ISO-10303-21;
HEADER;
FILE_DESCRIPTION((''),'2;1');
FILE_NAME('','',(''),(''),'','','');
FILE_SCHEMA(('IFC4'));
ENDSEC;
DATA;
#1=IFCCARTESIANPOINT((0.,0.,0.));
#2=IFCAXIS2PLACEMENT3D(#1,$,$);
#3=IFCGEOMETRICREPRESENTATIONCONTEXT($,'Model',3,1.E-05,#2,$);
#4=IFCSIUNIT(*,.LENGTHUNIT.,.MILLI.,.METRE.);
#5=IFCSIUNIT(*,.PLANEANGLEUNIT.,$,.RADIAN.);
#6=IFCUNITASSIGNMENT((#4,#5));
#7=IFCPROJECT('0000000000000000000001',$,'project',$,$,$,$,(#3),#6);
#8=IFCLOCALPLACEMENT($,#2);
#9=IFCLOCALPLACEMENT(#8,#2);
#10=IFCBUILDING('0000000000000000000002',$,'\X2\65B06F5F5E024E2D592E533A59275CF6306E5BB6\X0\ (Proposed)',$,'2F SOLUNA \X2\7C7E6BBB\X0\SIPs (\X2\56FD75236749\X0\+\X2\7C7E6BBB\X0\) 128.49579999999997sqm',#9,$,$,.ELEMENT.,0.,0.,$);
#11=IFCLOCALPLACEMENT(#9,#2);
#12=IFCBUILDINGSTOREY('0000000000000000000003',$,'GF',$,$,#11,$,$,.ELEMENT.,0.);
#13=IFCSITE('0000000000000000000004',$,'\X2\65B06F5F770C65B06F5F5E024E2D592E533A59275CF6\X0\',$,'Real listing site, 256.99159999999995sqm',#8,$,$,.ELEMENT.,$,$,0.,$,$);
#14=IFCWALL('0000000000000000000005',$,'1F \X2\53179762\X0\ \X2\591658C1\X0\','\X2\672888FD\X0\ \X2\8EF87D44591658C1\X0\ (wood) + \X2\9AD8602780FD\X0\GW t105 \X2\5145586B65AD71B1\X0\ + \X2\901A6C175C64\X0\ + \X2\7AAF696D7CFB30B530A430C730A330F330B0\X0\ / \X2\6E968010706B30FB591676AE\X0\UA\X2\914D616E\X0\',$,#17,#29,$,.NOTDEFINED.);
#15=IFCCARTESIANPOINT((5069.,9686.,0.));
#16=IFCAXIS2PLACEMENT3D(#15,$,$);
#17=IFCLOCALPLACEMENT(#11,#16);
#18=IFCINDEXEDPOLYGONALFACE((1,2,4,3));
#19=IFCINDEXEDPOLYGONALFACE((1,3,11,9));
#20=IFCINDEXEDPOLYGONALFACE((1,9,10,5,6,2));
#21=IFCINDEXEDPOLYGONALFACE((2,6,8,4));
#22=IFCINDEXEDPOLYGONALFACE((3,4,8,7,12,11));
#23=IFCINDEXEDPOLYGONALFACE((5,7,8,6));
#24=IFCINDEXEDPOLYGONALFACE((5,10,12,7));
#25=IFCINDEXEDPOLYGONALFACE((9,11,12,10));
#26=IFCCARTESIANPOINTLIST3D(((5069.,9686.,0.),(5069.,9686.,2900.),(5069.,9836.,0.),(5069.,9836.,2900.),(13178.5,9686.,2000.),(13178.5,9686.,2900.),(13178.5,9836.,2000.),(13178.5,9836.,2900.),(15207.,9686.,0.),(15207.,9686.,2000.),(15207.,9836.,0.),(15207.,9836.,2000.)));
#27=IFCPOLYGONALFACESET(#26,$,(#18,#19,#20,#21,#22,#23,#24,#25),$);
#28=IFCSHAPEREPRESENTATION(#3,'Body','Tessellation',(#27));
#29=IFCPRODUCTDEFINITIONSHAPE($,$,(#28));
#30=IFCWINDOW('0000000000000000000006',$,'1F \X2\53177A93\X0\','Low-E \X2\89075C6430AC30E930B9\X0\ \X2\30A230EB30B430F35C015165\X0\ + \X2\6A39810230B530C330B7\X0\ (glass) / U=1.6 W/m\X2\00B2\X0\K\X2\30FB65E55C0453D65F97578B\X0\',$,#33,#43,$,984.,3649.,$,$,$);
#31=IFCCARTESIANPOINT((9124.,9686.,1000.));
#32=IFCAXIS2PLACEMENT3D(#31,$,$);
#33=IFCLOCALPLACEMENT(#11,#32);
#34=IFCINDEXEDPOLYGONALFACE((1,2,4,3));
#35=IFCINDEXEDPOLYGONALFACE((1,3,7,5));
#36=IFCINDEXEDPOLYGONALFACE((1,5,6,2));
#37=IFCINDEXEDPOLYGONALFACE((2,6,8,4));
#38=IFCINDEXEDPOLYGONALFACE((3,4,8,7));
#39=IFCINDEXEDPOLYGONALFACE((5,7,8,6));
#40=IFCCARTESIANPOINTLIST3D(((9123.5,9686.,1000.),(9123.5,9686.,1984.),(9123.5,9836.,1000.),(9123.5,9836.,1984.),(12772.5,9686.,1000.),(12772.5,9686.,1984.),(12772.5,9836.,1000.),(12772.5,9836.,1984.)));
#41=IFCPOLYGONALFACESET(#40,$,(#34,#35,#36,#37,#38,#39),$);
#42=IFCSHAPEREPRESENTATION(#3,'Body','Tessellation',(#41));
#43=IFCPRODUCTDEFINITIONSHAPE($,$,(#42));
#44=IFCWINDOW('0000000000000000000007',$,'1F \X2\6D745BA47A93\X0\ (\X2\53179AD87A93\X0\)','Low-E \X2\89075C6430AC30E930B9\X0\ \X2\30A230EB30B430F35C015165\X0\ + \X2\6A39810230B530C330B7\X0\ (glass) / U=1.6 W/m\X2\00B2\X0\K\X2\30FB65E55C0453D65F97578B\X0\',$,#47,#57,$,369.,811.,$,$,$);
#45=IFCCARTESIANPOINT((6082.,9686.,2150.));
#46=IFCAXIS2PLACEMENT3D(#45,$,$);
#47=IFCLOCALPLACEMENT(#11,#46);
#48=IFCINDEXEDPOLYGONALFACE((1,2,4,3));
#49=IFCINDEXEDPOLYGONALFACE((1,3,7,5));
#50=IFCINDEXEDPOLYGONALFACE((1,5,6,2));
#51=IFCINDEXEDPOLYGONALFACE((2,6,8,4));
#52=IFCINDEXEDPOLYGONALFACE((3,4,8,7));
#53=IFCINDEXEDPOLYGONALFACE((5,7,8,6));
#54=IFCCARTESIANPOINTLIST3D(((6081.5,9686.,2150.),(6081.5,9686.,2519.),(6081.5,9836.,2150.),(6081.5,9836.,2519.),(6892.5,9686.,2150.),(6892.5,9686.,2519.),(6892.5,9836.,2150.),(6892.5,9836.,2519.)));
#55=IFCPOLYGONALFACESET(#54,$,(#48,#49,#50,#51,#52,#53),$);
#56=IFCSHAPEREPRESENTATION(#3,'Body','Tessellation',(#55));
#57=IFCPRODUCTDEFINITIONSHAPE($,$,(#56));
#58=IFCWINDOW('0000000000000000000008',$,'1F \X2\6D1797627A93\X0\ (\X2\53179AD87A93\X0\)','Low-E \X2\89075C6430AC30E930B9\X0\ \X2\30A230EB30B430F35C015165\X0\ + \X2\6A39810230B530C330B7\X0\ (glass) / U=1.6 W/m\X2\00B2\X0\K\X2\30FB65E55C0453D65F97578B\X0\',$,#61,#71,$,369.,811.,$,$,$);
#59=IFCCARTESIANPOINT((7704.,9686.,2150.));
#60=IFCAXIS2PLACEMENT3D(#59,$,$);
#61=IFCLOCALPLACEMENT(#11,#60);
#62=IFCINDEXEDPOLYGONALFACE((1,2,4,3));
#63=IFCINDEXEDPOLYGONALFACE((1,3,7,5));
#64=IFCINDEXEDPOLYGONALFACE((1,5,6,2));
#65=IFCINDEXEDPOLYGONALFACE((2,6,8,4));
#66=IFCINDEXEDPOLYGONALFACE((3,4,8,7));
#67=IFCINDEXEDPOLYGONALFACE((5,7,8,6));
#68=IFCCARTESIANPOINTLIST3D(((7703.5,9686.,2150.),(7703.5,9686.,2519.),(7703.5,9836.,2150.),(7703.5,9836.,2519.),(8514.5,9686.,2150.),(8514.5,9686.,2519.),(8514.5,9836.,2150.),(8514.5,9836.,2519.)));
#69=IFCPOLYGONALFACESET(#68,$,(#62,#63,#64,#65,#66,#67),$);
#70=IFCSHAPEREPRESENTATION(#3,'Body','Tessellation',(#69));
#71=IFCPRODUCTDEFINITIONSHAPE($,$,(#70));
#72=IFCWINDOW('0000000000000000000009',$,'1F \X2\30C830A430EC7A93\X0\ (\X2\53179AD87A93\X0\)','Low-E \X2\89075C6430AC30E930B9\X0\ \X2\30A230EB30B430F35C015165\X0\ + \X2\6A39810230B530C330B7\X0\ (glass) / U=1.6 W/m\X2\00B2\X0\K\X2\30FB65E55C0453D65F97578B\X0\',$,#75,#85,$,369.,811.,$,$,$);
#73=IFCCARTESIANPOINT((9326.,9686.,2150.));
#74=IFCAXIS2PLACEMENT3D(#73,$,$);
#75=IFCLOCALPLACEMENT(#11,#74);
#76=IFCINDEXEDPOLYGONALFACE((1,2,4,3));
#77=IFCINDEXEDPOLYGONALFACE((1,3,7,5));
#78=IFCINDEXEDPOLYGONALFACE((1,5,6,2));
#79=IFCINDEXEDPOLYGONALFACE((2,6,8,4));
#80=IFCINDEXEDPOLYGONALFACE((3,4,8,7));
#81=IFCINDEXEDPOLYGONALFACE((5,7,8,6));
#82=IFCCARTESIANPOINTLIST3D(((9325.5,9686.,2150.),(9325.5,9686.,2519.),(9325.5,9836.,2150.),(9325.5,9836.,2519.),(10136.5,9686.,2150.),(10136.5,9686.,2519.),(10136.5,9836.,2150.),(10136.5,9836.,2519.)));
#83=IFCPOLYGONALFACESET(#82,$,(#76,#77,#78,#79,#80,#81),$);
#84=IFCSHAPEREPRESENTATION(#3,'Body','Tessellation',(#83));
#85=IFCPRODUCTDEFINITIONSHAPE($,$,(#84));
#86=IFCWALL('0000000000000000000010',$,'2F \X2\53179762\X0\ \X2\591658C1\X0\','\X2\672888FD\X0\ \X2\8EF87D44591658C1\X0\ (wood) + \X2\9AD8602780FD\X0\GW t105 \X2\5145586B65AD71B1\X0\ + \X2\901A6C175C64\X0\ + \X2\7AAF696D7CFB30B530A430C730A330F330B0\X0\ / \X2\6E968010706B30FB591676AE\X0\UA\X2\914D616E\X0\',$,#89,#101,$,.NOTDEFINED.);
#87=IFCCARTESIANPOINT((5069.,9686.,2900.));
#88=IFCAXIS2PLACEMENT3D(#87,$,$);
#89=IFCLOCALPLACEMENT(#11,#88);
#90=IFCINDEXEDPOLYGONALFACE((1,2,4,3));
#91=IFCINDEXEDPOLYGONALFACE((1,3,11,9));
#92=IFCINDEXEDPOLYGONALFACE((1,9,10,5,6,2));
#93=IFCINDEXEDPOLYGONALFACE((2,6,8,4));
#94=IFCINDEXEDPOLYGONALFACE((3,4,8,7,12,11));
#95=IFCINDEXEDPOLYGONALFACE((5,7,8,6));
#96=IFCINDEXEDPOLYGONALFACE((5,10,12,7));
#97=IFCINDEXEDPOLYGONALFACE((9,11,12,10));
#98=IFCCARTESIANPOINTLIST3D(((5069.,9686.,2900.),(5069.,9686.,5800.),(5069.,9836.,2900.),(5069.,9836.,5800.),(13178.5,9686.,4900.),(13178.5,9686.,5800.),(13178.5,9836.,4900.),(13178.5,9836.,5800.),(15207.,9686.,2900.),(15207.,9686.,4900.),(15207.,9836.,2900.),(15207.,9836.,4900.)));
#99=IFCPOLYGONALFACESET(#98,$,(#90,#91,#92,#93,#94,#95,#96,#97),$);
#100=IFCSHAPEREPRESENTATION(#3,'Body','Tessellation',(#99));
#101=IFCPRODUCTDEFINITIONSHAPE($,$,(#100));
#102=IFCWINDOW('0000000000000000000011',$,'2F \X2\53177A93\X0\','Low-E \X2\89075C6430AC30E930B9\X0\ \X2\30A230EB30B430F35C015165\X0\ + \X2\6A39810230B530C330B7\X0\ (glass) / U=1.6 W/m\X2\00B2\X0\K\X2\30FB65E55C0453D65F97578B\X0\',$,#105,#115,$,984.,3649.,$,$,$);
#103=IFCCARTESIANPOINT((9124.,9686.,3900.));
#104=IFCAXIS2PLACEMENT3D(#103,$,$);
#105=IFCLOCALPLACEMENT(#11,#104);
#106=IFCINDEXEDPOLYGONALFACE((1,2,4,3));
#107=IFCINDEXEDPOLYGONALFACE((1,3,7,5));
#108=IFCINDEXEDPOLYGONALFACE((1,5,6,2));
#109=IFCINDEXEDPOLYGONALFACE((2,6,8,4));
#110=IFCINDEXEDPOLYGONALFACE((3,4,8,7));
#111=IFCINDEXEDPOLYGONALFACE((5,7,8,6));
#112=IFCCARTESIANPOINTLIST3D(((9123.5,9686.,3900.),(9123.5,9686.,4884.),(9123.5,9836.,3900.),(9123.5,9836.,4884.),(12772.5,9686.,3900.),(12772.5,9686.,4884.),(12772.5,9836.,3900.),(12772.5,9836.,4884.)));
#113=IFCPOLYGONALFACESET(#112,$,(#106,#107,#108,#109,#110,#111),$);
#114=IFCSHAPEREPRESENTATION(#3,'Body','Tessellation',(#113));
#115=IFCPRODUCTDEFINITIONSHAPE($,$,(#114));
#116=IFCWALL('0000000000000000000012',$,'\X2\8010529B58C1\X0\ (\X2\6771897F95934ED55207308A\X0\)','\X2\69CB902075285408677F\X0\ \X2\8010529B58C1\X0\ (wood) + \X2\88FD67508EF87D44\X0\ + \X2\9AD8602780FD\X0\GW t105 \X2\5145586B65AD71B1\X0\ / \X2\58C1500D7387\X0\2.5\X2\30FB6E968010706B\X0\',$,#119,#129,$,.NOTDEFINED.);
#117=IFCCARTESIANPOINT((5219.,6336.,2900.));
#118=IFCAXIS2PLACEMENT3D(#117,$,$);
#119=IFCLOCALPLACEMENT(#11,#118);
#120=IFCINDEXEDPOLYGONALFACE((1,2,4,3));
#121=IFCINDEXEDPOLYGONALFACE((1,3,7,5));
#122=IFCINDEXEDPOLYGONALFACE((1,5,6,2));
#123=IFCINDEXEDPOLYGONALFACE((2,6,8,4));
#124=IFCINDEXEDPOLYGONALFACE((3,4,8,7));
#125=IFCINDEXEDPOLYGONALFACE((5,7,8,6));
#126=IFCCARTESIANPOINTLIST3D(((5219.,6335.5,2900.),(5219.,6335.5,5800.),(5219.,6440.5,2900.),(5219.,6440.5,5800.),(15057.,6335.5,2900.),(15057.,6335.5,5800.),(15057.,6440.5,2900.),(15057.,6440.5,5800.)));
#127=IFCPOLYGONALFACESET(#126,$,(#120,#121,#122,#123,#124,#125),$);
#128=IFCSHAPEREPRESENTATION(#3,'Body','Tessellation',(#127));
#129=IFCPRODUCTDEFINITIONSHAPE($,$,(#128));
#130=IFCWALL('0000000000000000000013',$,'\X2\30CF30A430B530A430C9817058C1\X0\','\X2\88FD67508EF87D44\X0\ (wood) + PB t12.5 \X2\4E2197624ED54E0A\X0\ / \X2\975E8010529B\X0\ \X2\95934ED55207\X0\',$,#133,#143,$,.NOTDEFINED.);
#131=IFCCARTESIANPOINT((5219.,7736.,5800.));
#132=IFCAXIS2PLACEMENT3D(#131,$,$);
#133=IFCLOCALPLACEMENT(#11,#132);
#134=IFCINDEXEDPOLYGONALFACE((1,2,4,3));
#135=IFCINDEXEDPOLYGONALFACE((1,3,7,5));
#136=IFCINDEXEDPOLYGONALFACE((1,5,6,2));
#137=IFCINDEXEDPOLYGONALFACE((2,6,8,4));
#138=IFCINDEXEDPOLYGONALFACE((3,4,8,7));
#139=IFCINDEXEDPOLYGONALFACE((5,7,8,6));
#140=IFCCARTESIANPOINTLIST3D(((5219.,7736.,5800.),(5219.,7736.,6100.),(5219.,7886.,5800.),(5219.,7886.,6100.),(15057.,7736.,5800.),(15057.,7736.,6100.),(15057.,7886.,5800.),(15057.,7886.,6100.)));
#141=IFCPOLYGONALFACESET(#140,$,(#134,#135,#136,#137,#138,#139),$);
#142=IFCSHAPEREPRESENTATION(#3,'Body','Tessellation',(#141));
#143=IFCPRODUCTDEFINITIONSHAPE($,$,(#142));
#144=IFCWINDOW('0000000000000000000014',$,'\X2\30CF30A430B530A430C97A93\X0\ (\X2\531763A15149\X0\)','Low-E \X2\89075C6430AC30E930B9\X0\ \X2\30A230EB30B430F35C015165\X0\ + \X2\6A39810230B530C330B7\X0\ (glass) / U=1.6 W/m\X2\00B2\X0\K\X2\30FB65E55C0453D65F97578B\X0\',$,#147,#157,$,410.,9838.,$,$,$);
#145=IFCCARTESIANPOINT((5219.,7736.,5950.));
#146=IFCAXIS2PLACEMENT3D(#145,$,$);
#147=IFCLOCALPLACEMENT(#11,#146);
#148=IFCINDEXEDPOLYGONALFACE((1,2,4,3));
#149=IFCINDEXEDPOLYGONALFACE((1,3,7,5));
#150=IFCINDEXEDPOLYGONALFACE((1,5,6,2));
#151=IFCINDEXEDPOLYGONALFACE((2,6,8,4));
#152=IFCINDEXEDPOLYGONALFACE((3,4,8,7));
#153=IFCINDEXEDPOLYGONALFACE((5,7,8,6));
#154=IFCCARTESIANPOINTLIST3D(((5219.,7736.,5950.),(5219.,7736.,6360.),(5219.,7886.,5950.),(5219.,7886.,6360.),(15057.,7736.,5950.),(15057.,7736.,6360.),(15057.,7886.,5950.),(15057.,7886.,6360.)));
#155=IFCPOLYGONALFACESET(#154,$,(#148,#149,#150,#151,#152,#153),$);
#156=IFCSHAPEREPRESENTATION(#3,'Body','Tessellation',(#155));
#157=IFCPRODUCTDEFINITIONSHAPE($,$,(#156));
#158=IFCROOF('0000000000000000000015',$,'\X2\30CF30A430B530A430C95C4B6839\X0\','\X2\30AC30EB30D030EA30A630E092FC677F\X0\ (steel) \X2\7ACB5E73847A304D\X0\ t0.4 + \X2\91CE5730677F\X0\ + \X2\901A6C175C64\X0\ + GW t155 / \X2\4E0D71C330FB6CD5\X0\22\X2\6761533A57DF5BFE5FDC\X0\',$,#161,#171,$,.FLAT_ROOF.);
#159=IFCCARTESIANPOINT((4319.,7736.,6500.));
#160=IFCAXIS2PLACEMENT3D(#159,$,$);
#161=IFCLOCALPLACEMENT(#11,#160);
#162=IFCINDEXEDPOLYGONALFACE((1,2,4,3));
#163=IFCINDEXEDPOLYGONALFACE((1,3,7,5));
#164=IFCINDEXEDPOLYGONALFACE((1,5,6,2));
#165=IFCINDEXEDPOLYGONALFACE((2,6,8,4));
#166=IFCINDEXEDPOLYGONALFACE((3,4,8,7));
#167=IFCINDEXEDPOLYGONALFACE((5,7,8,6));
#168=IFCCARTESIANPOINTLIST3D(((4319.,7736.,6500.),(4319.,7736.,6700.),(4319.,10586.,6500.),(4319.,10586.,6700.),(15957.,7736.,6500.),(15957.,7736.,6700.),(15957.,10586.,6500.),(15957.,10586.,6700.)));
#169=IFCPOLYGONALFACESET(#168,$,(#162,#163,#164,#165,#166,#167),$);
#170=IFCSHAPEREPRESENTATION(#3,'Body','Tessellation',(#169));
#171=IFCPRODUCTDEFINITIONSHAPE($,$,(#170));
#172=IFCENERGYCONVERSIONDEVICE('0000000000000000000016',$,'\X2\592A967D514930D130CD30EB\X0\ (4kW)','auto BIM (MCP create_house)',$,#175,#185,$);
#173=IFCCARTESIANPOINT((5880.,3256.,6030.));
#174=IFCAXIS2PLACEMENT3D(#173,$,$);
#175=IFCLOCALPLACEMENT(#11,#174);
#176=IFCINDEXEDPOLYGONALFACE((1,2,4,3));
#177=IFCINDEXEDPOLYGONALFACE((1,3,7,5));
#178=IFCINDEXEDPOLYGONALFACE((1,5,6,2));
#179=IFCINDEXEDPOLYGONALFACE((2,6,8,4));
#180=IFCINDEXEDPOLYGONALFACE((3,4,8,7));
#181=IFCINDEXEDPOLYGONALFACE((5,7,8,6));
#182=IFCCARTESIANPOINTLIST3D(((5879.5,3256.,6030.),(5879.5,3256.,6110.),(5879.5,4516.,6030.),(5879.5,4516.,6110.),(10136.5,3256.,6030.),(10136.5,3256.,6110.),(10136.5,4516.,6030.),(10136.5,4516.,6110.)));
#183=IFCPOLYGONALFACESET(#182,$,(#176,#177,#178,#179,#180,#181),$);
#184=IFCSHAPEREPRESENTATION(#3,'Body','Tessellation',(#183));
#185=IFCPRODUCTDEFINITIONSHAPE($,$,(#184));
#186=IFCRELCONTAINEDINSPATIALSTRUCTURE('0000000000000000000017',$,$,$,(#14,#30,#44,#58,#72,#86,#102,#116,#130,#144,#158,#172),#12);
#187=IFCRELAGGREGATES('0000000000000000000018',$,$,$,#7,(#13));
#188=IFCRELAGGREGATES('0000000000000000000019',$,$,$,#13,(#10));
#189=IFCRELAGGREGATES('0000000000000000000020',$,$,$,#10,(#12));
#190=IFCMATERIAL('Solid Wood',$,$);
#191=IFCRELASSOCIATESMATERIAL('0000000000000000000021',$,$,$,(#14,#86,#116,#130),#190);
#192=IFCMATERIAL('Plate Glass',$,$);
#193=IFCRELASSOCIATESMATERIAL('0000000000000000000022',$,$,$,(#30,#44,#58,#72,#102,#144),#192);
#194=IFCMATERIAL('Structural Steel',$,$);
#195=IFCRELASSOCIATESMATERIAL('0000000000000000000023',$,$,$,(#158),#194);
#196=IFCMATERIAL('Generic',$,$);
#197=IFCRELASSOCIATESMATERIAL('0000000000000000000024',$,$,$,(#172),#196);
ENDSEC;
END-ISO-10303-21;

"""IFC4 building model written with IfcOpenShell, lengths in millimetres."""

from ifc_helpers import new_model, si_unit, frame, frame_2d, origin, place, context, project, spatial, rectangle, extrude, material, element, fill, save


model = new_model("IFC4")

# Units and contexts
model_context = context("Model", 3, precision=1e-05, world=origin())
ifc_project = project(units=[si_unit("LENGTHUNIT", "METRE", prefix="MILLI"), si_unit("PLANEANGLEUNIT", "RADIAN")], contexts=[model_context])

# Site, building, storey
site_placement = place(None, origin())
site = spatial("IfcSite", under=ifc_project, at=site_placement, Name="新潟県新潟市中央区大島", ObjectType="Real listing site, 256.99159999999995sqm", CompositionType="ELEMENT", RefElevation=0.0)
building_placement = place(site_placement, origin())
building = spatial("IfcBuilding", under=site, at=building_placement, Name="新潟市中央区大島の家 (Proposed)", ObjectType="2F SOLUNA 籾殻SIPs (国産杉+籾殻) 128.49579999999997sqm", CompositionType="ELEMENT", ElevationOfRefHeight=0.0, ElevationOfTerrain=0.0)
storey_placement = place(building_placement, origin())
storey = spatial("IfcBuildingStorey", under=building, at=storey_placement, Name="GF", CompositionType="ELEMENT", Elevation=0.0)

# Wall, openings, windows
ifc_material_1 = material(Name="Solid Wood")
wall_1_placement = place(storey_placement, frame((5069.0, 9686.0, 0.0)))
wall_1 = element("IfcWall", 1, at=wall_1_placement, inside=storey, material=ifc_material_1, Name="1F 北面 外壁", Description="木製 軸組外壁 (wood) + 高性能GW t105 充填断熱 + 通気層 + 窯業系サイディング / 準耐火・外皮UA配慮", PredefinedType="NOTDEFINED", context=model_context, shape_type="SweptSolid", body=[
    extrude(rectangle(XDim=10138.0, YDim=150.0, at=frame_2d((5069.0, 75.0))), frame((5069.0, 9686.0, 0.0)), (0.0, 0.0, 1.0), 2900.0),
])
opening_1_placement = place(storey_placement, frame((9124.0, 9686.0, 1000.0)))
opening_1 = element("IfcOpeningElement", 2, at=opening_1_placement, cuts=wall_1, PredefinedType="NOTDEFINED", context=model_context, shape_type="SweptSolid", body=[
    extrude(rectangle(XDim=3649.0, YDim=150.0, at=frame_2d((1824.0, 75.0))), frame((9124.0, 9686.0, 1000.0)), (0.0, 0.0, 1.0), 984.0),
])
opening_2_placement = place(storey_placement, frame((6082.0, 9686.0, 2150.0)))
opening_2 = element("IfcOpeningElement", 3, at=opening_2_placement, cuts=wall_1, PredefinedType="NOTDEFINED", context=model_context, shape_type="SweptSolid", body=[
    extrude(rectangle(XDim=811.0, YDim=150.0, at=frame_2d((405.0, 75.0))), frame((6082.0, 9686.0, 2150.0)), (0.0, 0.0, 1.0), 369.0),
])
opening_3_placement = place(storey_placement, frame((7704.0, 9686.0, 2150.0)))
opening_3 = element("IfcOpeningElement", 4, at=opening_3_placement, cuts=wall_1, PredefinedType="NOTDEFINED", context=model_context, shape_type="SweptSolid", body=[
    extrude(rectangle(XDim=811.0, YDim=150.0, at=frame_2d((405.0, 75.0))), frame((7704.0, 9686.0, 2150.0)), (0.0, 0.0, 1.0), 369.0),
])
opening_4_placement = place(storey_placement, frame((9326.0, 9686.0, 2150.0)))
opening_4 = element("IfcOpeningElement", 5, at=opening_4_placement, cuts=wall_1, PredefinedType="NOTDEFINED", context=model_context, shape_type="SweptSolid", body=[
    extrude(rectangle(XDim=811.0, YDim=150.0, at=frame_2d((405.0, 75.0))), frame((9326.0, 9686.0, 2150.0)), (0.0, 0.0, 1.0), 369.0),
])
ifc_material_2 = material(Name="Plate Glass")
window_1_placement = place(storey_placement, frame((9124.0, 9686.0, 1000.0)))
window_1 = element("IfcWindow", 6, at=window_1_placement, inside=storey, material=ifc_material_2, Name="1F 北窓", Description="Low-E 複層ガラス アルゴン封入 + 樹脂サッシ (glass) / U=1.6 W/m²K・日射取得型", OverallHeight=984.0, OverallWidth=3649.0, context=model_context, shape_type="SweptSolid", body=[
    extrude(rectangle(XDim=3649.0, YDim=150.0, at=frame_2d((1824.0, 75.0))), frame((9124.0, 9686.0, 1000.0)), (0.0, 0.0, 1.0), 984.0),
])
fill(opening_1, window_1)
window_2_placement = place(storey_placement, frame((6082.0, 9686.0, 2150.0)))
window_2 = element("IfcWindow", 7, at=window_2_placement, inside=storey, material=ifc_material_2, Name="1F 浴室窓 (北高窓)", Description="Low-E 複層ガラス アルゴン封入 + 樹脂サッシ (glass) / U=1.6 W/m²K・日射取得型", OverallHeight=369.0, OverallWidth=811.0, context=model_context, shape_type="SweptSolid", body=[
    extrude(rectangle(XDim=811.0, YDim=150.0, at=frame_2d((405.0, 75.0))), frame((6082.0, 9686.0, 2150.0)), (0.0, 0.0, 1.0), 369.0),
])
fill(opening_2, window_2)
window_3_placement = place(storey_placement, frame((7704.0, 9686.0, 2150.0)))
window_3 = element("IfcWindow", 8, at=window_3_placement, inside=storey, material=ifc_material_2, Name="1F 洗面窓 (北高窓)", Description="Low-E 複層ガラス アルゴン封入 + 樹脂サッシ (glass) / U=1.6 W/m²K・日射取得型", OverallHeight=369.0, OverallWidth=811.0, context=model_context, shape_type="SweptSolid", body=[
    extrude(rectangle(XDim=811.0, YDim=150.0, at=frame_2d((405.0, 75.0))), frame((7704.0, 9686.0, 2150.0)), (0.0, 0.0, 1.0), 369.0),
])
fill(opening_3, window_3)
window_4_placement = place(storey_placement, frame((9326.0, 9686.0, 2150.0)))
window_4 = element("IfcWindow", 9, at=window_4_placement, inside=storey, material=ifc_material_2, Name="1F トイレ窓 (北高窓)", Description="Low-E 複層ガラス アルゴン封入 + 樹脂サッシ (glass) / U=1.6 W/m²K・日射取得型", OverallHeight=369.0, OverallWidth=811.0, context=model_context, shape_type="SweptSolid", body=[
    extrude(rectangle(XDim=811.0, YDim=150.0, at=frame_2d((405.0, 75.0))), frame((9326.0, 9686.0, 2150.0)), (0.0, 0.0, 1.0), 369.0),
])
fill(opening_4, window_4)

# Wall, opening, window
wall_2_placement = place(storey_placement, frame((5069.0, 9686.0, 2900.0)))
wall_2 = element("IfcWall", 10, at=wall_2_placement, inside=storey, material=ifc_material_1, Name="2F 北面 外壁", Description="木製 軸組外壁 (wood) + 高性能GW t105 充填断熱 + 通気層 + 窯業系サイディング / 準耐火・外皮UA配慮", PredefinedType="NOTDEFINED", context=model_context, shape_type="SweptSolid", body=[
    extrude(rectangle(XDim=10138.0, YDim=150.0, at=frame_2d((5069.0, 75.0))), frame((5069.0, 9686.0, 2900.0)), (0.0, 0.0, 1.0), 2900.0),
])
opening_5_placement = place(storey_placement, frame((9124.0, 9686.0, 3900.0)))
opening_5 = element("IfcOpeningElement", 11, at=opening_5_placement, cuts=wall_2, PredefinedType="NOTDEFINED", context=model_context, shape_type="SweptSolid", body=[
    extrude(rectangle(XDim=3649.0, YDim=150.0, at=frame_2d((1824.0, 75.0))), frame((9124.0, 9686.0, 3900.0)), (0.0, 0.0, 1.0), 984.0),
])
window_5_placement = place(storey_placement, frame((9124.0, 9686.0, 3900.0)))
window_5 = element("IfcWindow", 12, at=window_5_placement, inside=storey, material=ifc_material_2, Name="2F 北窓", Description="Low-E 複層ガラス アルゴン封入 + 樹脂サッシ (glass) / U=1.6 W/m²K・日射取得型", OverallHeight=984.0, OverallWidth=3649.0, context=model_context, shape_type="SweptSolid", body=[
    extrude(rectangle(XDim=3649.0, YDim=150.0, at=frame_2d((1824.0, 75.0))), frame((9124.0, 9686.0, 3900.0)), (0.0, 0.0, 1.0), 984.0),
])
fill(opening_5, window_5)

# Wall
wall_3_placement = place(storey_placement, frame((5219.0, 6336.0, 2900.0)))
element("IfcWall", 13, at=wall_3_placement, inside=storey, material=ifc_material_1, Name="耐力壁 (東西間仕切り)", Description="構造用合板 耐力壁 (wood) + 製材軸組 + 高性能GW t105 充填断熱 / 壁倍率2.5・準耐火", PredefinedType="NOTDEFINED", context=model_context, shape_type="SweptSolid", body=[
    extrude(rectangle(XDim=9838.0, YDim=105.0, at=frame_2d((4919.0, 52.0))), frame((5219.0, 6336.0, 2900.0)), (0.0, 0.0, 1.0), 2900.0),
])

# Wall, opening, window
wall_4_placement = place(storey_placement, frame((5219.0, 7736.0, 5800.0)))
wall_4 = element("IfcWall", 14, at=wall_4_placement, inside=storey, material=ifc_material_1, Name="ハイサイド腰壁", Description="製材軸組 (wood) + PB t12.5 両面仕上 / 非耐力 間仕切", PredefinedType="NOTDEFINED", context=model_context, shape_type="SweptSolid", body=[
    extrude(rectangle(XDim=9838.0, YDim=150.0, at=frame_2d((4919.0, 75.0))), frame((5219.0, 7736.0, 5800.0)), (0.0, 0.0, 1.0), 700.0),
])
opening_6_placement = place(storey_placement, frame((5219.0, 7736.0, 5950.0)))
opening_6 = element("IfcOpeningElement", 15, at=opening_6_placement, cuts=wall_4, PredefinedType="NOTDEFINED", context=model_context, shape_type="SweptSolid", body=[
    extrude(rectangle(XDim=9838.0, YDim=150.0, at=frame_2d((4919.0, 75.0))), frame((5219.0, 7736.0, 5950.0)), (0.0, 0.0, 1.0), 410.0),
])
window_6_placement = place(storey_placement, frame((5219.0, 7736.0, 5950.0)))
window_6 = element("IfcWindow", 16, at=window_6_placement, inside=storey, material=ifc_material_2, Name="ハイサイド窓 (北採光)", Description="Low-E 複層ガラス アルゴン封入 + 樹脂サッシ (glass) / U=1.6 W/m²K・日射取得型", OverallHeight=410.0, OverallWidth=9838.0, context=model_context, shape_type="SweptSolid", body=[
    extrude(rectangle(XDim=9838.0, YDim=150.0, at=frame_2d((4919.0, 75.0))), frame((5219.0, 7736.0, 5950.0)), (0.0, 0.0, 1.0), 410.0),
])
fill(opening_6, window_6)

# Roof
ifc_material_3 = material(Name="Structural Steel")
roof_placement = place(storey_placement, frame((4319.0, 7736.0, 6500.0)))
element("IfcRoof", 17, at=roof_placement, inside=storey, material=ifc_material_3, Name="ハイサイド屋根", Description="ガルバリウム鋼板 (steel) 立平葺き t0.4 + 野地板 + 通気層 + GW t155 / 不燃・法22条区域対応", PredefinedType="FLAT_ROOF", context=model_context, shape_type="SweptSolid", body=[
    extrude(rectangle(XDim=11638.0, YDim=2850.0, at=frame_2d((5819.0, 1425.0))), frame((4319.0, 7736.0, 6500.0)), (0.0, 0.0, 1.0), 200.0),
])

# Energy conversion device
ifc_material_4 = material(Name="Generic")
energy_conversion_device_placement = place(storey_placement, frame((5880.0, 3256.0, 6030.0)))
element("IfcEnergyConversionDevice", 18, at=energy_conversion_device_placement, inside=storey, material=ifc_material_4, Name="太陽光パネル (4kW)", Description="auto BIM (MCP create_house)", context=model_context, shape_type="SweptSolid", body=[
    extrude(rectangle(XDim=4257.0, YDim=1260.0, at=frame_2d((2128.0, 630.0))), frame((5880.0, 3256.0, 6030.0)), (0.0, 0.0, 1.0), 80.0),
])

save(model, "model.ifc")
